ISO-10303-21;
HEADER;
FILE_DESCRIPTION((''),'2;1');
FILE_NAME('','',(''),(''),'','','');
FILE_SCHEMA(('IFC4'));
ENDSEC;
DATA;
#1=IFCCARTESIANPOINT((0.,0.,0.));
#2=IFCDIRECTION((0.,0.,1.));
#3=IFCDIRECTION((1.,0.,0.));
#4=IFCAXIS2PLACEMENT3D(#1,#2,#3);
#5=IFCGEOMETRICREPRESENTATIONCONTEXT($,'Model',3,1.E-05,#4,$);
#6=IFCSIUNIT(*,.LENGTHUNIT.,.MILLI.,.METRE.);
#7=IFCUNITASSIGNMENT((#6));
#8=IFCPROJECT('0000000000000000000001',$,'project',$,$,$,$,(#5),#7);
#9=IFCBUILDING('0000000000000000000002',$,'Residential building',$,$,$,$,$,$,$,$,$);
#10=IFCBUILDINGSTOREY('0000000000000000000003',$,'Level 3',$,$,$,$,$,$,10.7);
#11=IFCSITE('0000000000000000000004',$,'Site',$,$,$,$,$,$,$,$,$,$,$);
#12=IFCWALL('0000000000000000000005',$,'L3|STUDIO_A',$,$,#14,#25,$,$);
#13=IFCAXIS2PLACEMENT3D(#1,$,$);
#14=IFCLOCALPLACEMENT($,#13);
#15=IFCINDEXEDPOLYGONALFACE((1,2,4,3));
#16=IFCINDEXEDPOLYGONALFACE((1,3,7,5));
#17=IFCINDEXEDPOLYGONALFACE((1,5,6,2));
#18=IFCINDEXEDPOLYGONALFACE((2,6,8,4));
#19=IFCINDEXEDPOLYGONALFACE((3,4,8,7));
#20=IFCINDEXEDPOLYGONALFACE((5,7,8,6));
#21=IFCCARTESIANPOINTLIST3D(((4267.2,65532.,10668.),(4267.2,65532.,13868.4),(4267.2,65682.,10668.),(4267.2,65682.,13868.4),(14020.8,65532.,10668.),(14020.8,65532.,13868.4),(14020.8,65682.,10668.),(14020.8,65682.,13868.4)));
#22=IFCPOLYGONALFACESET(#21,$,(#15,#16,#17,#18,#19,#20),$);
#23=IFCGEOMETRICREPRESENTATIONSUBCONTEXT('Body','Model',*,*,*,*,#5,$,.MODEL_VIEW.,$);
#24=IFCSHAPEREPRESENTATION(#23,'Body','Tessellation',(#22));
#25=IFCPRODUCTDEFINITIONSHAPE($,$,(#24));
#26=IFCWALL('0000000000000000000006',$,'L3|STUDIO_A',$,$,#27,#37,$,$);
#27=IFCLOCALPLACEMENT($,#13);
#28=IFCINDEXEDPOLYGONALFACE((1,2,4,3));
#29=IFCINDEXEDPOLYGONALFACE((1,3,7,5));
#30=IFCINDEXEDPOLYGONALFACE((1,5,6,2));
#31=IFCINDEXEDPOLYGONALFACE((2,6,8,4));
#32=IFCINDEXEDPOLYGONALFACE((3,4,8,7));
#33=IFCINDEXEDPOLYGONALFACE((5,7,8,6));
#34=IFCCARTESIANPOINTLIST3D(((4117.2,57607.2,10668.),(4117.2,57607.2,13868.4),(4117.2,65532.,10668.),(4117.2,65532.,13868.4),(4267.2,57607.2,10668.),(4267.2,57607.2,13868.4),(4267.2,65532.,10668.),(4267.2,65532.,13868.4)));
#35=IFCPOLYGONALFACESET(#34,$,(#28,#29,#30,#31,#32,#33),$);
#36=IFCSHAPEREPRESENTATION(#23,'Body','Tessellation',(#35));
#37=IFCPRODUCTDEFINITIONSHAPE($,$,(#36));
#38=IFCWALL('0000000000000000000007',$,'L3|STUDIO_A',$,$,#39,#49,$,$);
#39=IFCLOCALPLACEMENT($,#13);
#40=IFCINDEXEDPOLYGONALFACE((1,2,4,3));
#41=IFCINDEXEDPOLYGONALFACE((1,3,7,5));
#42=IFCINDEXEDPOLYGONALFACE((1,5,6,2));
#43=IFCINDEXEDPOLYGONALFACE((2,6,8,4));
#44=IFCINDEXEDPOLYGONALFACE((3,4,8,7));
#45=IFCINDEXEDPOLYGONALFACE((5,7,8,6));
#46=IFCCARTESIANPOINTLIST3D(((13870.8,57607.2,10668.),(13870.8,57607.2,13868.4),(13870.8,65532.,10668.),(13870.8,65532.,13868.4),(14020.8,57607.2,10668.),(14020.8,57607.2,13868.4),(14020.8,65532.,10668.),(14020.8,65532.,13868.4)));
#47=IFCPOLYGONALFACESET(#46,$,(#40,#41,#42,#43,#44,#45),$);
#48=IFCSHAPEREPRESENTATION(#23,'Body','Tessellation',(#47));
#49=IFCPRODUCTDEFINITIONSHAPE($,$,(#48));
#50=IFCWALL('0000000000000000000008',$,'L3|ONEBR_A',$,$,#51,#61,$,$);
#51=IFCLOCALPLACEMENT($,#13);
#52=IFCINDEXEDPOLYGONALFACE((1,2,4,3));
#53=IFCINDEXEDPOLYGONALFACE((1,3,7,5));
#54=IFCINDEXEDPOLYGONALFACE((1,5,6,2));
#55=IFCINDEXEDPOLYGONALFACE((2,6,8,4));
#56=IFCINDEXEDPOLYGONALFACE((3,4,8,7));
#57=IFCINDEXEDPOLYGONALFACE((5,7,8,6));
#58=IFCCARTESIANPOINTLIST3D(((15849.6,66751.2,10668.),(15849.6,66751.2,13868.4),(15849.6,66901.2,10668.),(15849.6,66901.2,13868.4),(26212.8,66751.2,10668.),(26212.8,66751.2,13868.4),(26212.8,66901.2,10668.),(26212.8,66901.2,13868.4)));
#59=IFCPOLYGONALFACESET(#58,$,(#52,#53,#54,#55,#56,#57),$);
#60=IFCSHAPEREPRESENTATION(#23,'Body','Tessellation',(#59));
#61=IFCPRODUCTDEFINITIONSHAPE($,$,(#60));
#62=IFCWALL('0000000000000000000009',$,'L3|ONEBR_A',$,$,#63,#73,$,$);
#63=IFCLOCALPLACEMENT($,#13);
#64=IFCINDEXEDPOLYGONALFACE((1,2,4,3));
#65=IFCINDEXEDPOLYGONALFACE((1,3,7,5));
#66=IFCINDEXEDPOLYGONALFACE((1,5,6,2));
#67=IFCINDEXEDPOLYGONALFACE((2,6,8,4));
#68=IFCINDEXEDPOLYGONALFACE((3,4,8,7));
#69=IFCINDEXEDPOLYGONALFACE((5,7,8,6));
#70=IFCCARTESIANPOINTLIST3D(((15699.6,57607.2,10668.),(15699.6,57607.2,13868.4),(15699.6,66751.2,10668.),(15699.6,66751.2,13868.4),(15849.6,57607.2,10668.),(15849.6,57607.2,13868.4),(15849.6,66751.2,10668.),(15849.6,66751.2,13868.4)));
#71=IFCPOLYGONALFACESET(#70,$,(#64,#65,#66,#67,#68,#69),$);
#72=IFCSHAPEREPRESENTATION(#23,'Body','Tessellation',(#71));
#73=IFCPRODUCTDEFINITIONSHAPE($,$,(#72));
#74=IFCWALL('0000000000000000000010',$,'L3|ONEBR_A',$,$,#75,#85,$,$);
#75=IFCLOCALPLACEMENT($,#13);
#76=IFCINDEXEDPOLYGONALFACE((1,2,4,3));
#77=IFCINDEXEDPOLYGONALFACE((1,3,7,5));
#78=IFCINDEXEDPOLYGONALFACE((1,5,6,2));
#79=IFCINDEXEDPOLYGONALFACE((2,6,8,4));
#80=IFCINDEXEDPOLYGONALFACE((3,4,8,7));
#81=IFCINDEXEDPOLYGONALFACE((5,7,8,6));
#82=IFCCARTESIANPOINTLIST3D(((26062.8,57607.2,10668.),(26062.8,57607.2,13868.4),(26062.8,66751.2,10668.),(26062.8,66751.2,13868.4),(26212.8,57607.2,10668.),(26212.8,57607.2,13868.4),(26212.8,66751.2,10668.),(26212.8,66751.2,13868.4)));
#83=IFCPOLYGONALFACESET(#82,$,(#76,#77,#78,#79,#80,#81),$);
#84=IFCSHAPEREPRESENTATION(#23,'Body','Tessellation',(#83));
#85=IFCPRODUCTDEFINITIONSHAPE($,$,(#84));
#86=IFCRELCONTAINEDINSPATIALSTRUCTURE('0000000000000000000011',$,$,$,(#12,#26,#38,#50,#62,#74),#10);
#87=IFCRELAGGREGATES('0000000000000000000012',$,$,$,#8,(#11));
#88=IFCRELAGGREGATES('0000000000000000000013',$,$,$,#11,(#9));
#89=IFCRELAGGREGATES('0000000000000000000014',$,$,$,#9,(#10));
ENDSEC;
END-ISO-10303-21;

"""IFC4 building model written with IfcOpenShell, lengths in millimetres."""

from ifc_helpers import new_model, si_unit, frame, origin_with_axes, place, context, subcontext, project, spatial, indexed_curve, outline, extrude, element, save


model = new_model("IFC4")

# Units and contexts
model_context = context("Model", 3, precision=1e-05, world=origin_with_axes())
body_context = subcontext(model_context, "Body", "Model", "MODEL_VIEW")
ifc_project = project(units=[si_unit("LENGTHUNIT", "METRE", prefix="MILLI")], contexts=[model_context])

# Site, building, storey
site = spatial("IfcSite", under=ifc_project, Name="Site")
building = spatial("IfcBuilding", under=site, Name="Residential building")
storey = spatial("IfcBuildingStorey", under=building, Name="Level 3", Elevation=10.7)

# Walls
for number, where, z_axis, x_axis, name in (
    (1, (4267.2, 65532.0, 10668.0), (0.0, 0.0, 1.0), (1.0, 0.0, 0.0), "L3|STUDIO_A"),
):
    element("IfcWall", number, at=place(None, frame(where, z_axis=z_axis, x_axis=x_axis)), inside=storey, Name=name, context=body_context, shape_type="SweptSolid", body=[
        extrude(outline(indexed_curve([(0.0, 0.0), (0.0, 150.0), (9753.6, 150.0), (9753.6, 0.0), (0.0, 0.0)], self_intersect=False)), origin_with_axes(), (0.0, 0.0, 1.0), 3200.4),
    ])
for number, where, z_axis, x_axis, name in (
    (2, (4267.2, 57607.2, 10668.0), (0.0, 0.0, 1.0), (0.0, 1.0, 0.0), "L3|STUDIO_A"),
    (3, (14020.8, 57607.2, 10668.0), (0.0, 0.0, 1.0), (0.0, 1.0, 0.0), "L3|STUDIO_A"),
):
    element("IfcWall", number, at=place(None, frame(where, z_axis=z_axis, x_axis=x_axis)), inside=storey, Name=name, context=body_context, shape_type="SweptSolid", body=[
        extrude(outline(indexed_curve([(0.0, 0.0), (0.0, 150.0), (7924.8, 150.0), (7924.8, 0.0), (0.0, 0.0)], self_intersect=False)), origin_with_axes(), (0.0, 0.0, 1.0), 3200.4),
    ])
for number, where, z_axis, x_axis, name in (
    (4, (15849.6, 66751.2, 10668.0), (0.0, 0.0, 1.0), (1.0, 0.0, 0.0), "L3|ONEBR_A"),
):
    element("IfcWall", number, at=place(None, frame(where, z_axis=z_axis, x_axis=x_axis)), inside=storey, Name=name, context=body_context, shape_type="SweptSolid", body=[
        extrude(outline(indexed_curve([(0.0, 0.0), (0.0, 150.0), (10363.2, 150.0), (10363.2, 0.0), (0.0, 0.0)], self_intersect=False)), origin_with_axes(), (0.0, 0.0, 1.0), 3200.4),
    ])
for number, where, z_axis, x_axis, name in (
    (5, (15849.6, 57607.2, 10668.0), (0.0, 0.0, 1.0), (0.0, 1.0, 0.0), "L3|ONEBR_A"),
    (6, (26212.8, 57607.2, 10668.0), (0.0, 0.0, 1.0), (0.0, 1.0, 0.0), "L3|ONEBR_A"),
):
    element("IfcWall", number, at=place(None, frame(where, z_axis=z_axis, x_axis=x_axis)), inside=storey, Name=name, context=body_context, shape_type="SweptSolid", body=[
        extrude(outline(indexed_curve([(0.0, 0.0), (0.0, 150.0), (9144.0, 150.0), (9144.0, 0.0), (0.0, 0.0)], self_intersect=False)), origin_with_axes(), (0.0, 0.0, 1.0), 3200.4),
    ])

save(model, "model.ifc")
